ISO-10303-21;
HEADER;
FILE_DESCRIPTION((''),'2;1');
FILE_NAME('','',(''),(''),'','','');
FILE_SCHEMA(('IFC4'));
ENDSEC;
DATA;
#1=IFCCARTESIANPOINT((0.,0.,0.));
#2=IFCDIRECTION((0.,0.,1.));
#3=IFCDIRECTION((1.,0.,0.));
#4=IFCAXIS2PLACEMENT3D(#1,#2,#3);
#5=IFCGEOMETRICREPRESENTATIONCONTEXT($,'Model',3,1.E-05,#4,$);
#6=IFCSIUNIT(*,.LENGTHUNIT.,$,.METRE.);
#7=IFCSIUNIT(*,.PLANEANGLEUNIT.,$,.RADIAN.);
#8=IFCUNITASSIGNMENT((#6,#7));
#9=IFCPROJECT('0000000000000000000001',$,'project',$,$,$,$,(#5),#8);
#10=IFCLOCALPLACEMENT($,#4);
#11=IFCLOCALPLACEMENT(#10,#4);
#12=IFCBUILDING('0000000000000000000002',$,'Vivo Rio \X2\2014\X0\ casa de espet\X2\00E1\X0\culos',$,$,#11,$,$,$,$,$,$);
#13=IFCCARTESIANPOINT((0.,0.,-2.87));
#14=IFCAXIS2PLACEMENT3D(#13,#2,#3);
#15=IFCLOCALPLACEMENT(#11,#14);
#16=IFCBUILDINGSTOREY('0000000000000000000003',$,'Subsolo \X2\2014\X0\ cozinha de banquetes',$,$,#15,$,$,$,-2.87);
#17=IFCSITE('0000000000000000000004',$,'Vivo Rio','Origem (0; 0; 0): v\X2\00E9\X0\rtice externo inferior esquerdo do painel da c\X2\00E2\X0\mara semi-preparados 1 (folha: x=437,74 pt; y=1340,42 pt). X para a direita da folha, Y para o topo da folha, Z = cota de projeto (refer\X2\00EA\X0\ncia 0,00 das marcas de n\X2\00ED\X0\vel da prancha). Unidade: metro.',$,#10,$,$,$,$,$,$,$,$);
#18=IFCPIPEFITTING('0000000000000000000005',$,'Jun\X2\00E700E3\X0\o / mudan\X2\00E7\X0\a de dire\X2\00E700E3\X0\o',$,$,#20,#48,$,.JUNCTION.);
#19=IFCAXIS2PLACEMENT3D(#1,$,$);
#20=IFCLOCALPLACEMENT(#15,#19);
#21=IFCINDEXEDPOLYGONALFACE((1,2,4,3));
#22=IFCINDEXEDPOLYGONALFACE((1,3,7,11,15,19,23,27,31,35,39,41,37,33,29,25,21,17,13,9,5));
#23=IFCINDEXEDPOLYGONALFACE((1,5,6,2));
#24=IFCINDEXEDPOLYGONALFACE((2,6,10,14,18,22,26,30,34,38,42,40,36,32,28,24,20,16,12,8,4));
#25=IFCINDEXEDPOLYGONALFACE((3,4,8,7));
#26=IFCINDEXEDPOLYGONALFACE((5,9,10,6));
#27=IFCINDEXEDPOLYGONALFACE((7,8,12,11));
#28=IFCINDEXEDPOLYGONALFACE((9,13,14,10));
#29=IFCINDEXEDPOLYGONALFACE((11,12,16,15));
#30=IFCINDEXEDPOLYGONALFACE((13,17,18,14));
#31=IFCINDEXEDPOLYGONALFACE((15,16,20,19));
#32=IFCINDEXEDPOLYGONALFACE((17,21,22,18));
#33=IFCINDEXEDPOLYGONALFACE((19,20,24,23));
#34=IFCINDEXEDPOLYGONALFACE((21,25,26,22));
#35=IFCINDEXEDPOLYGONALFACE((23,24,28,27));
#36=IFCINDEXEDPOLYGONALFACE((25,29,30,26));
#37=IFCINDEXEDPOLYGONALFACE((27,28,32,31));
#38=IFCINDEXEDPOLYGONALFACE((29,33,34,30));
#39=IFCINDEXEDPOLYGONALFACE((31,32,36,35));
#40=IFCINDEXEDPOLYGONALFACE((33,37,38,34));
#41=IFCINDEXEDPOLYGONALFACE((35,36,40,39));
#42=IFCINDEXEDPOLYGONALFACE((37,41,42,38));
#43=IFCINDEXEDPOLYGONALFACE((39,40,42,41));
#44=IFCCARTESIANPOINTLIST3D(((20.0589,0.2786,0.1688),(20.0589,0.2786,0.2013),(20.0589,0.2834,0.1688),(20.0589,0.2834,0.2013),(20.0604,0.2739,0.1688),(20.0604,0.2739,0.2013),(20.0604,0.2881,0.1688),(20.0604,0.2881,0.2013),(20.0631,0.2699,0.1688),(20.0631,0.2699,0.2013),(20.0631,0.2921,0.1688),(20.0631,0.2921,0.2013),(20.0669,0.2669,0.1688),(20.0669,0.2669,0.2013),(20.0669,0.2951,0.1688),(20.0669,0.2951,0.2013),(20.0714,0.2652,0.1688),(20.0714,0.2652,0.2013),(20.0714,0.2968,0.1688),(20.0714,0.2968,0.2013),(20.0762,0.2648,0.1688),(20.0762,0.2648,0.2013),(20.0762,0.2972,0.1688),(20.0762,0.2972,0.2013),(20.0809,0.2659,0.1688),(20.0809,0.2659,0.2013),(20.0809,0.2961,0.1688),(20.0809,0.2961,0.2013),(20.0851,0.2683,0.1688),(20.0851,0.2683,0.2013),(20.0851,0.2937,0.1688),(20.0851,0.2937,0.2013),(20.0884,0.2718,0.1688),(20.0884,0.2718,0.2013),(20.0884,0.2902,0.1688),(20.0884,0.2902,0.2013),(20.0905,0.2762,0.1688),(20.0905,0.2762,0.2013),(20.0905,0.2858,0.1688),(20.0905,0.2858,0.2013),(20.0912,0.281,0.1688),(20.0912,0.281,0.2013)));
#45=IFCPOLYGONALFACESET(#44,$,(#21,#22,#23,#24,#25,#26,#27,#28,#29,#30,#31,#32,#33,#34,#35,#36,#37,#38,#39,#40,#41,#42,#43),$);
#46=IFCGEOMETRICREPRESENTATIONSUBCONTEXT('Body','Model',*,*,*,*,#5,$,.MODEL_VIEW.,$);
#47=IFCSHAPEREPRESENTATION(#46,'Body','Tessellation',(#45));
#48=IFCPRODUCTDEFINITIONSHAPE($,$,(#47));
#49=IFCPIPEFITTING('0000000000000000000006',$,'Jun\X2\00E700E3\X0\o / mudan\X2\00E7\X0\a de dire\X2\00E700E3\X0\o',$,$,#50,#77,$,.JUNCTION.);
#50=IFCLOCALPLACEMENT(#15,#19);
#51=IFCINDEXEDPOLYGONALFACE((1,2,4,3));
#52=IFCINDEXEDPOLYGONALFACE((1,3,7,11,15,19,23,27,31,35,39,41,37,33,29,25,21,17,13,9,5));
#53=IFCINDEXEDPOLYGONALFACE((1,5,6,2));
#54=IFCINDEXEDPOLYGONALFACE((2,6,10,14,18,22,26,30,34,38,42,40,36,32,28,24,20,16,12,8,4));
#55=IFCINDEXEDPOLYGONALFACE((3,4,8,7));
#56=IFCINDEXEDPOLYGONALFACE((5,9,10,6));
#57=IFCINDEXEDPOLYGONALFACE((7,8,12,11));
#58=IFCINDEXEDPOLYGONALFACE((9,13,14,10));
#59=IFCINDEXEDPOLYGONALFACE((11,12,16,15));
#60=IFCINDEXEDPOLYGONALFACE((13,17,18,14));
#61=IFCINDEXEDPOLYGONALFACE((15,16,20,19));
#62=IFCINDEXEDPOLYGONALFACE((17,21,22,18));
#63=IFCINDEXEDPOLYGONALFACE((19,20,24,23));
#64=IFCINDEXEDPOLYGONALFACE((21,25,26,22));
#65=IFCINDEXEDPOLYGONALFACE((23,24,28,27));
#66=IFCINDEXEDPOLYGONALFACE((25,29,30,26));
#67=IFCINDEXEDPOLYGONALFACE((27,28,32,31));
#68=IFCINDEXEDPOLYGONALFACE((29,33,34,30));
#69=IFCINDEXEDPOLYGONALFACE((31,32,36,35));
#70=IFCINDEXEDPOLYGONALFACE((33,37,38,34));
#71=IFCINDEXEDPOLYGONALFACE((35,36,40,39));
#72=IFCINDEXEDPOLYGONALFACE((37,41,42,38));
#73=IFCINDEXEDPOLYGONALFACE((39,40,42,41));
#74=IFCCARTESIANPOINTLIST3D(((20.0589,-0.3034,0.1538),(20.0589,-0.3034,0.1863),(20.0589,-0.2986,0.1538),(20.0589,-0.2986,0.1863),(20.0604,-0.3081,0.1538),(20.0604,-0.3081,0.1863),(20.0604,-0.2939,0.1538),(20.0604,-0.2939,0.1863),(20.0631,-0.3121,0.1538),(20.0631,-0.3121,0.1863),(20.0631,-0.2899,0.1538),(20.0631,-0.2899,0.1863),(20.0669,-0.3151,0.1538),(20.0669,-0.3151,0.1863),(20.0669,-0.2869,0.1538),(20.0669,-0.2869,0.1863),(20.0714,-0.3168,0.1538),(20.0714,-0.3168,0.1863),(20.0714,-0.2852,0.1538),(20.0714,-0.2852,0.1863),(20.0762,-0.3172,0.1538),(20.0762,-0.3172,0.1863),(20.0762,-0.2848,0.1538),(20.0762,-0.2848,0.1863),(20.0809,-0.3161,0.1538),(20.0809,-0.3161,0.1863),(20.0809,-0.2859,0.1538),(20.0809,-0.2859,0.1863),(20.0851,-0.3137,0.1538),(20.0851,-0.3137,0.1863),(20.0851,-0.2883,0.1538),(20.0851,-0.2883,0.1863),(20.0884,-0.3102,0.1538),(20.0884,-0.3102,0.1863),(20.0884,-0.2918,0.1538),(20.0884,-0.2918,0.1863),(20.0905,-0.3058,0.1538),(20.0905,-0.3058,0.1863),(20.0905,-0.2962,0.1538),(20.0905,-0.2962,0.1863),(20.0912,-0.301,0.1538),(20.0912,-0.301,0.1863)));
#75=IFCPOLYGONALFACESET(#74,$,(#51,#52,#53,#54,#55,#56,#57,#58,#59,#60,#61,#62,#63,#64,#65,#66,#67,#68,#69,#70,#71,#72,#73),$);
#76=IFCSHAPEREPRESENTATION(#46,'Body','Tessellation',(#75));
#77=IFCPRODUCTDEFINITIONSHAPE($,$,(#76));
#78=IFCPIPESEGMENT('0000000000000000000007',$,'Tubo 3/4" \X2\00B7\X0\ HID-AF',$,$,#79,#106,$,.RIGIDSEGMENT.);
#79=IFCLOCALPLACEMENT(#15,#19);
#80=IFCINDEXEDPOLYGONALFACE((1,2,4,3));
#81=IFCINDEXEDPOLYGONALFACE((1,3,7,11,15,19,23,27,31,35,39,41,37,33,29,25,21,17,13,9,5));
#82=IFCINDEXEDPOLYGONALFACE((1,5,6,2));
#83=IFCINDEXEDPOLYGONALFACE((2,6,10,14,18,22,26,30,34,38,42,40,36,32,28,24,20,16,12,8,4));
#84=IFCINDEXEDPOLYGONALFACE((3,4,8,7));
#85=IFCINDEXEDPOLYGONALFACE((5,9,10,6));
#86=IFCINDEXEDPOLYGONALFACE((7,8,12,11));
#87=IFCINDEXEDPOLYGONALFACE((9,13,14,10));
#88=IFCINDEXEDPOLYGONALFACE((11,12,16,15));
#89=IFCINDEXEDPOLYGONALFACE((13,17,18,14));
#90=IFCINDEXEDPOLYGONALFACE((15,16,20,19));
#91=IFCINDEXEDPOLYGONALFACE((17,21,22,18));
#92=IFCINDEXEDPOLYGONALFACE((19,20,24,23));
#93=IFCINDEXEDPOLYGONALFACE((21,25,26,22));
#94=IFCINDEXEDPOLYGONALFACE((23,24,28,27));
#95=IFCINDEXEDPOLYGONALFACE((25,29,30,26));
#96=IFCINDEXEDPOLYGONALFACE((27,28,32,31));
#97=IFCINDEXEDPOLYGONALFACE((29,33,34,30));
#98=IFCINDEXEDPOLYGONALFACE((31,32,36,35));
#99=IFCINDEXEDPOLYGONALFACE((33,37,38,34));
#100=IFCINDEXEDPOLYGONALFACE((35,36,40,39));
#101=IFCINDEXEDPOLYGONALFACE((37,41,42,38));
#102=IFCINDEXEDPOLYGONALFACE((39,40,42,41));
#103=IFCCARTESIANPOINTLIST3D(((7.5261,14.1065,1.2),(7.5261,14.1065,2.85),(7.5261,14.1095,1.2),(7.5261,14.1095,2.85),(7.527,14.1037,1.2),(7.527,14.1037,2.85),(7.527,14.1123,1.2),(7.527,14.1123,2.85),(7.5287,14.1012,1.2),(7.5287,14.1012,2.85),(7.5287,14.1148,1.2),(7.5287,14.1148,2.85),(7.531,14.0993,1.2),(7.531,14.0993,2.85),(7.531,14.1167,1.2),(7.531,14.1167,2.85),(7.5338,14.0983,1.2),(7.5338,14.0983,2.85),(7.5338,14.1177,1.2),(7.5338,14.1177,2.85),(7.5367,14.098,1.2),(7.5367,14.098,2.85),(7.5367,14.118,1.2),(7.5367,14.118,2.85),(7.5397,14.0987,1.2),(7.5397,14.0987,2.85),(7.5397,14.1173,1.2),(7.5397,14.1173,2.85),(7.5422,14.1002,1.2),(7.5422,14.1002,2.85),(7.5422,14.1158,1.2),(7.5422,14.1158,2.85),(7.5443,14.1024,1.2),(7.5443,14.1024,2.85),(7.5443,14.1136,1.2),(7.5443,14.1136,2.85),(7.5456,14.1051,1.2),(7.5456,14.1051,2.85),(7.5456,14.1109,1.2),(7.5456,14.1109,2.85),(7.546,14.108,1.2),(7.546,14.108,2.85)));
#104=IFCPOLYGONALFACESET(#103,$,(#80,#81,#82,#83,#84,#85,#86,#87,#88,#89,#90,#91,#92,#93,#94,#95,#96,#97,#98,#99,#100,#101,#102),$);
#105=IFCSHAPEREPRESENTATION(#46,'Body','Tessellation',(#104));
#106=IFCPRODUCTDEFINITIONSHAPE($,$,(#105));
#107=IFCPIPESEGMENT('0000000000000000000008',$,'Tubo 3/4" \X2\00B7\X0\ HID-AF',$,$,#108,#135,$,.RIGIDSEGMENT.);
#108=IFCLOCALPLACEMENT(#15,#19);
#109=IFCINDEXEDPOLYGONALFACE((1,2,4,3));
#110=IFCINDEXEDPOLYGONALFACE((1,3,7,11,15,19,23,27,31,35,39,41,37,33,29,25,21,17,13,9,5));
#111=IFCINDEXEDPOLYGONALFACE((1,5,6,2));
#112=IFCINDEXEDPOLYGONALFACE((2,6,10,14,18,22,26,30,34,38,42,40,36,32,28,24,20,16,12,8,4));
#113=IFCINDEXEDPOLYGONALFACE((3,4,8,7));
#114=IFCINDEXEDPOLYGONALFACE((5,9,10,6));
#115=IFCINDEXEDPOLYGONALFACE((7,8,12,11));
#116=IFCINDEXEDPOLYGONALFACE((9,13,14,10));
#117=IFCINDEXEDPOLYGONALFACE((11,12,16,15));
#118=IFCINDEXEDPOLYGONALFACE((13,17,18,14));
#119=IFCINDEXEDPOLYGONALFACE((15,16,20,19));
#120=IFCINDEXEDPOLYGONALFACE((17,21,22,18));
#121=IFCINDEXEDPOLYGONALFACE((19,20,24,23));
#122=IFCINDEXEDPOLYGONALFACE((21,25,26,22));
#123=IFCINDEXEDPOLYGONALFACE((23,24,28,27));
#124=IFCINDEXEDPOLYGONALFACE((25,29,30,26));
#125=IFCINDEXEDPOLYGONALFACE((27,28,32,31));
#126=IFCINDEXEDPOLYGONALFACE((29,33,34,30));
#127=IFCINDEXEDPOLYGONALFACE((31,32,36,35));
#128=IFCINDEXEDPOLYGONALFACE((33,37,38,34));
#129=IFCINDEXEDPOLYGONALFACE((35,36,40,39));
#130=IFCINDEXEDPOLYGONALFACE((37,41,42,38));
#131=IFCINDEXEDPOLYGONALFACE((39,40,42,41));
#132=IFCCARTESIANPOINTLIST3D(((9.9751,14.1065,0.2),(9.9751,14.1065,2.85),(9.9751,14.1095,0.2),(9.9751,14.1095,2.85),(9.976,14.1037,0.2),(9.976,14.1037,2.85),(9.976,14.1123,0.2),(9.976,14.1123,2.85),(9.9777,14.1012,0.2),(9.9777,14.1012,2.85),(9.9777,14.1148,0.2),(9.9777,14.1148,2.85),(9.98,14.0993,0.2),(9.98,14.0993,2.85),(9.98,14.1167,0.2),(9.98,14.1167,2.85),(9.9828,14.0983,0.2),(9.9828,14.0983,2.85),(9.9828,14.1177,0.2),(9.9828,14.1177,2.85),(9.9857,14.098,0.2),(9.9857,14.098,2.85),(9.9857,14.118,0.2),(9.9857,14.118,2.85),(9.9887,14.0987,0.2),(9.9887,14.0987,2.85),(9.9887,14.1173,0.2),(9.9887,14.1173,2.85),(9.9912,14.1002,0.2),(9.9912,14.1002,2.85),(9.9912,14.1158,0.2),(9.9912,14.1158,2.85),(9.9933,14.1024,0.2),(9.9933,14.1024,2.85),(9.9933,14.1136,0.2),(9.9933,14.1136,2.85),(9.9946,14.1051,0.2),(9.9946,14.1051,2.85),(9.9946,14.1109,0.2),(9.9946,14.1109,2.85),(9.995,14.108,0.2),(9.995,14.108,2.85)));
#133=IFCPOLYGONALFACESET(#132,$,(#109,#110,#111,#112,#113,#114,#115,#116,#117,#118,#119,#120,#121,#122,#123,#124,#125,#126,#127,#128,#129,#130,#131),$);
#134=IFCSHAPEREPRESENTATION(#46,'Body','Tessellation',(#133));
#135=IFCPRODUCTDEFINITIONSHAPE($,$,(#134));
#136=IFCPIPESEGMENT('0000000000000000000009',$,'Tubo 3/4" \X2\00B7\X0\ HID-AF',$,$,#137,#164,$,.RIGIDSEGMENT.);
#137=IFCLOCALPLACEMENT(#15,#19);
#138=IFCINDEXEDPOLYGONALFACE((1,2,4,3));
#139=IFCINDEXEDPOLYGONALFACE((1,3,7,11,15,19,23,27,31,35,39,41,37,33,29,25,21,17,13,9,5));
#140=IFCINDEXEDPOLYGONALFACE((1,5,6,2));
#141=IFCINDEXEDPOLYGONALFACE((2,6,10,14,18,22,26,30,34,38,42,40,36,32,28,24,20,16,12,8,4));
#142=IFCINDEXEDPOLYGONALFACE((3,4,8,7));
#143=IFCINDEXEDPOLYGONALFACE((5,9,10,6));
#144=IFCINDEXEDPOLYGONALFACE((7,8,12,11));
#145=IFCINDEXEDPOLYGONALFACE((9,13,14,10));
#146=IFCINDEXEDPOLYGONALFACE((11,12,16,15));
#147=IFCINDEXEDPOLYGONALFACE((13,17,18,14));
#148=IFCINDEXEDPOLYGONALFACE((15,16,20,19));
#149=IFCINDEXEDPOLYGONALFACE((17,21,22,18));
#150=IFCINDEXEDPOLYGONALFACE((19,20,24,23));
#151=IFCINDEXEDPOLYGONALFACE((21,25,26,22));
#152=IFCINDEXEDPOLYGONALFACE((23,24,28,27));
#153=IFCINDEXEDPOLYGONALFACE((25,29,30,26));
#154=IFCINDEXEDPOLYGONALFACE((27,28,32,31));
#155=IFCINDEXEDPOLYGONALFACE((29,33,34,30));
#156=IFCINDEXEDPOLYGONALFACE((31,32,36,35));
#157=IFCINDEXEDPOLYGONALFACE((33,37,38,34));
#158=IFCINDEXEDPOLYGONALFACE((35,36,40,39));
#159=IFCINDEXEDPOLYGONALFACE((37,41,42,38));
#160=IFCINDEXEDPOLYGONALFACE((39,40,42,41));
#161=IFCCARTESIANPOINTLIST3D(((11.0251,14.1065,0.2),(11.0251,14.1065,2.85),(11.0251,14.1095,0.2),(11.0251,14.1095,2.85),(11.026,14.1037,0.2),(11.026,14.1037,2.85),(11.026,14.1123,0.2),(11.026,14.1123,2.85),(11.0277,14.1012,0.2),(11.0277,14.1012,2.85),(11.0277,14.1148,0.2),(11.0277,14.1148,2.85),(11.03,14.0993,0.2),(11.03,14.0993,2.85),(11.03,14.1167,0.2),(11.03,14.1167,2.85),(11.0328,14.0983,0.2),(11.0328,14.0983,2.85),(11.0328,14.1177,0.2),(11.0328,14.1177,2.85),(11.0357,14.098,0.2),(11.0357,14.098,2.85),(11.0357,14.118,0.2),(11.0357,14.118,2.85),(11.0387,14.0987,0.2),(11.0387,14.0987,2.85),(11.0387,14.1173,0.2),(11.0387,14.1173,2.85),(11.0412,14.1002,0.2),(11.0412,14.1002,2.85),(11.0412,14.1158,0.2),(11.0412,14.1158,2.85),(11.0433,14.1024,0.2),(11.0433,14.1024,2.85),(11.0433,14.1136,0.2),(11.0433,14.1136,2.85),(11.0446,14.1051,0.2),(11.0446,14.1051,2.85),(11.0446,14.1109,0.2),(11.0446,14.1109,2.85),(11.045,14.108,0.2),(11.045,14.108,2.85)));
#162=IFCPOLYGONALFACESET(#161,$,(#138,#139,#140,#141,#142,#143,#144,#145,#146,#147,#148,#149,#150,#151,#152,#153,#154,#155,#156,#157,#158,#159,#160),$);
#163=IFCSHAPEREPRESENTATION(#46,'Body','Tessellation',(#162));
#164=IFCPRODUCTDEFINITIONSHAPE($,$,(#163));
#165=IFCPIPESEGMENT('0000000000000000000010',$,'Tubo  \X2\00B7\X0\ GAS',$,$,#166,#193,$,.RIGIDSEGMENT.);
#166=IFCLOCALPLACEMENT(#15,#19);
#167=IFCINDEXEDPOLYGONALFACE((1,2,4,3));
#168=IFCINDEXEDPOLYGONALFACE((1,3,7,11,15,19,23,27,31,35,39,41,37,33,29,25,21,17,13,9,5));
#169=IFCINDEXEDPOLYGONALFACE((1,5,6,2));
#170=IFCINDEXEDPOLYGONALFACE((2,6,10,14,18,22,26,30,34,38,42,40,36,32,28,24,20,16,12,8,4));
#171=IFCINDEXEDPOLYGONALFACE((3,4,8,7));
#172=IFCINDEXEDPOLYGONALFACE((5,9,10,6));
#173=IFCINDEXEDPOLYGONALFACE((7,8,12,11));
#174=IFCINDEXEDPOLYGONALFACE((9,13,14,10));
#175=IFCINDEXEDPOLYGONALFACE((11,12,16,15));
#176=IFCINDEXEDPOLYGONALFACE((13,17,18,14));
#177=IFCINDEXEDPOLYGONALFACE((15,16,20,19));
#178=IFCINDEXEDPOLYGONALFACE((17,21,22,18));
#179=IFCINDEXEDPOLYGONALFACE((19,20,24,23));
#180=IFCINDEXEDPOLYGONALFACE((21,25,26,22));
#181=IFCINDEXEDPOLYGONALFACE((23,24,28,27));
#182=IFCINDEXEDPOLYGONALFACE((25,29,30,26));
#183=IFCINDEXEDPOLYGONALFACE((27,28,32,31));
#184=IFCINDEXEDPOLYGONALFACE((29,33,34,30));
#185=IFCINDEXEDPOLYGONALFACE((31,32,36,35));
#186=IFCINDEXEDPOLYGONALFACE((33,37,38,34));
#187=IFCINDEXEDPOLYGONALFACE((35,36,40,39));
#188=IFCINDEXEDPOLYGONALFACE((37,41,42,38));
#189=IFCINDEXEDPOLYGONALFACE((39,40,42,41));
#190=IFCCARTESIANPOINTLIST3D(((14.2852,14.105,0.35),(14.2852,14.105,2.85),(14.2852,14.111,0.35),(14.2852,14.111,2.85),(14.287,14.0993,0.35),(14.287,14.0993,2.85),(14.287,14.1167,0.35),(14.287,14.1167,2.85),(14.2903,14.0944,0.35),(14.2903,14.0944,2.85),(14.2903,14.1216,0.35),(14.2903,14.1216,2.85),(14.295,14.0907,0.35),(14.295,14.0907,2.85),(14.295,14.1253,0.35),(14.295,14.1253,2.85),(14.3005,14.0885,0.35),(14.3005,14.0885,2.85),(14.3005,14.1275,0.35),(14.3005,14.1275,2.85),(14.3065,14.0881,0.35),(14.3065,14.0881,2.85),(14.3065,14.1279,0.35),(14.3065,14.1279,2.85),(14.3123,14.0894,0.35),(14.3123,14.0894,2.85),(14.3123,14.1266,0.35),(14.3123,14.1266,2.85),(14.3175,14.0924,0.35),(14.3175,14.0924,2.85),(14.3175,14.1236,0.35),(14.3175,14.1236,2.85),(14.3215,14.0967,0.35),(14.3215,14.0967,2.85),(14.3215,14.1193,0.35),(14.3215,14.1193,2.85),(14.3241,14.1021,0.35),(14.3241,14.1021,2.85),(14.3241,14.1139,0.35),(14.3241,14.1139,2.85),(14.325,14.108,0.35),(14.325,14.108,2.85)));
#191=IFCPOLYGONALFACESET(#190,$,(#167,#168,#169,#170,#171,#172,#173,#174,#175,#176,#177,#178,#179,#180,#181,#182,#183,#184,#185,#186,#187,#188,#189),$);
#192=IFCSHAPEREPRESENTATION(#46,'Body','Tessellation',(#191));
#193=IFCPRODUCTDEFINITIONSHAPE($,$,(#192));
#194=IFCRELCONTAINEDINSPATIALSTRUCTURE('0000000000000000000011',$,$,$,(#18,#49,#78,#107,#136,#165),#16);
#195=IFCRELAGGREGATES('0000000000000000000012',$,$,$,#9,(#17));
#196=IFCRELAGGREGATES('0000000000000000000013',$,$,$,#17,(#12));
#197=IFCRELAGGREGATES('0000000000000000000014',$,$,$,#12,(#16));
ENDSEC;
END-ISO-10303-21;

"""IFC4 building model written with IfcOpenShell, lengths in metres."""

from ifc_helpers import new_model, si_unit, frame, origin_with_axes, origin_2d, place, context, subcontext, project, spatial, circle, extrude, element, save


model = new_model("IFC4")

# Units and contexts
model_context = context("Model", 3, precision=1e-05, world=origin_with_axes())
body_context = subcontext(model_context, "Body", "Model", "MODEL_VIEW")
ifc_project = project(units=[si_unit("LENGTHUNIT", "METRE"), si_unit("PLANEANGLEUNIT", "RADIAN")], contexts=[model_context])

# Site, building, storey
site_placement = place(None, origin_with_axes())
site = spatial("IfcSite", under=ifc_project, at=site_placement, Name="Vivo Rio", Description="Origem (0; 0; 0): vértice externo inferior esquerdo do painel da câmara semi-preparados 1 (folha: x=437,74 pt; y=1340,42 pt). X para a direita da folha, Y para o topo da folha, Z = cota de projeto (referência 0,00 das marcas de nível da prancha). Unidade: metro.")
building_placement = place(site_placement, origin_with_axes())
building = spatial("IfcBuilding", under=site, at=building_placement, Name="Vivo Rio — casa de espetáculos")
storey_placement = place(building_placement, frame((0.0, 0.0, -2.87), z_axis=(0.0, 0.0, 1.0), x_axis=(1.0, 0.0, 0.0)))
storey = spatial("IfcBuildingStorey", under=building, at=storey_placement, Name="Subsolo — cozinha de banquetes", Elevation=-2.87)

# Pipe fittings
pipe_fitting_1_placement = place(storey_placement, origin_with_axes())
element("IfcPipeFitting", 1, at=pipe_fitting_1_placement, inside=storey, Name="Junção / mudança de direção", PredefinedType="JUNCTION", context=body_context, shape_type="SweptSolid", body=[
    extrude(circle(Radius=0.0163, at=origin_2d()), frame((20.075, 0.281, 0.1688), z_axis=(0.0, 0.0, 1.0), x_axis=(1.0, 0.0, 0.0)), (0.0, 0.0, 1.0), 0.0325),
])
pipe_fitting_2_placement = place(storey_placement, origin_with_axes())
element("IfcPipeFitting", 2, at=pipe_fitting_2_placement, inside=storey, Name="Junção / mudança de direção", PredefinedType="JUNCTION", context=body_context, shape_type="SweptSolid", body=[
    extrude(circle(Radius=0.0163, at=origin_2d()), frame((20.075, -0.301, 0.1538), z_axis=(0.0, 0.0, 1.0), x_axis=(1.0, 0.0, 0.0)), (0.0, 0.0, 1.0), 0.0325),
])

# Pipe segments
pipe_segment_1_placement = place(storey_placement, origin_with_axes())
element("IfcPipeSegment", 3, at=pipe_segment_1_placement, inside=storey, Name="Tubo 3/4\" · HID-AF", PredefinedType="RIGIDSEGMENT", context=body_context, shape_type="SweptSolid", body=[
    extrude(circle(Radius=0.01, at=origin_2d()), frame((7.536, 14.108, 2.85), z_axis=(0.0, 0.0, -1.0), x_axis=(1.0, 0.0, 0.0)), (0.0, 0.0, 1.0), 1.65),
])
pipe_segment_2_placement = place(storey_placement, origin_with_axes())
element("IfcPipeSegment", 4, at=pipe_segment_2_placement, inside=storey, Name="Tubo 3/4\" · HID-AF", PredefinedType="RIGIDSEGMENT", context=body_context, shape_type="SweptSolid", body=[
    extrude(circle(Radius=0.01, at=origin_2d()), frame((9.985, 14.108, 2.85), z_axis=(0.0, 0.0, -1.0), x_axis=(1.0, 0.0, 0.0)), (0.0, 0.0, 1.0), 2.65),
])
pipe_segment_3_placement = place(storey_placement, origin_with_axes())
element("IfcPipeSegment", 5, at=pipe_segment_3_placement, inside=storey, Name="Tubo 3/4\" · HID-AF", PredefinedType="RIGIDSEGMENT", context=body_context, shape_type="SweptSolid", body=[
    extrude(circle(Radius=0.01, at=origin_2d()), frame((11.035, 14.108, 2.85), z_axis=(0.0, 0.0, -1.0), x_axis=(1.0, 0.0, 0.0)), (0.0, 0.0, 1.0), 2.65),
])
pipe_segment_4_placement = place(storey_placement, origin_with_axes())
element("IfcPipeSegment", 6, at=pipe_segment_4_placement, inside=storey, Name="Tubo  · GAS", PredefinedType="RIGIDSEGMENT", context=body_context, shape_type="SweptSolid", body=[
    extrude(circle(Radius=0.02, at=origin_2d()), frame((14.305, 14.108, 2.85), z_axis=(0.0, 0.0, -1.0), x_axis=(1.0, 0.0, 0.0)), (0.0, 0.0, 1.0), 2.5),
])

save(model, "model.ifc")
